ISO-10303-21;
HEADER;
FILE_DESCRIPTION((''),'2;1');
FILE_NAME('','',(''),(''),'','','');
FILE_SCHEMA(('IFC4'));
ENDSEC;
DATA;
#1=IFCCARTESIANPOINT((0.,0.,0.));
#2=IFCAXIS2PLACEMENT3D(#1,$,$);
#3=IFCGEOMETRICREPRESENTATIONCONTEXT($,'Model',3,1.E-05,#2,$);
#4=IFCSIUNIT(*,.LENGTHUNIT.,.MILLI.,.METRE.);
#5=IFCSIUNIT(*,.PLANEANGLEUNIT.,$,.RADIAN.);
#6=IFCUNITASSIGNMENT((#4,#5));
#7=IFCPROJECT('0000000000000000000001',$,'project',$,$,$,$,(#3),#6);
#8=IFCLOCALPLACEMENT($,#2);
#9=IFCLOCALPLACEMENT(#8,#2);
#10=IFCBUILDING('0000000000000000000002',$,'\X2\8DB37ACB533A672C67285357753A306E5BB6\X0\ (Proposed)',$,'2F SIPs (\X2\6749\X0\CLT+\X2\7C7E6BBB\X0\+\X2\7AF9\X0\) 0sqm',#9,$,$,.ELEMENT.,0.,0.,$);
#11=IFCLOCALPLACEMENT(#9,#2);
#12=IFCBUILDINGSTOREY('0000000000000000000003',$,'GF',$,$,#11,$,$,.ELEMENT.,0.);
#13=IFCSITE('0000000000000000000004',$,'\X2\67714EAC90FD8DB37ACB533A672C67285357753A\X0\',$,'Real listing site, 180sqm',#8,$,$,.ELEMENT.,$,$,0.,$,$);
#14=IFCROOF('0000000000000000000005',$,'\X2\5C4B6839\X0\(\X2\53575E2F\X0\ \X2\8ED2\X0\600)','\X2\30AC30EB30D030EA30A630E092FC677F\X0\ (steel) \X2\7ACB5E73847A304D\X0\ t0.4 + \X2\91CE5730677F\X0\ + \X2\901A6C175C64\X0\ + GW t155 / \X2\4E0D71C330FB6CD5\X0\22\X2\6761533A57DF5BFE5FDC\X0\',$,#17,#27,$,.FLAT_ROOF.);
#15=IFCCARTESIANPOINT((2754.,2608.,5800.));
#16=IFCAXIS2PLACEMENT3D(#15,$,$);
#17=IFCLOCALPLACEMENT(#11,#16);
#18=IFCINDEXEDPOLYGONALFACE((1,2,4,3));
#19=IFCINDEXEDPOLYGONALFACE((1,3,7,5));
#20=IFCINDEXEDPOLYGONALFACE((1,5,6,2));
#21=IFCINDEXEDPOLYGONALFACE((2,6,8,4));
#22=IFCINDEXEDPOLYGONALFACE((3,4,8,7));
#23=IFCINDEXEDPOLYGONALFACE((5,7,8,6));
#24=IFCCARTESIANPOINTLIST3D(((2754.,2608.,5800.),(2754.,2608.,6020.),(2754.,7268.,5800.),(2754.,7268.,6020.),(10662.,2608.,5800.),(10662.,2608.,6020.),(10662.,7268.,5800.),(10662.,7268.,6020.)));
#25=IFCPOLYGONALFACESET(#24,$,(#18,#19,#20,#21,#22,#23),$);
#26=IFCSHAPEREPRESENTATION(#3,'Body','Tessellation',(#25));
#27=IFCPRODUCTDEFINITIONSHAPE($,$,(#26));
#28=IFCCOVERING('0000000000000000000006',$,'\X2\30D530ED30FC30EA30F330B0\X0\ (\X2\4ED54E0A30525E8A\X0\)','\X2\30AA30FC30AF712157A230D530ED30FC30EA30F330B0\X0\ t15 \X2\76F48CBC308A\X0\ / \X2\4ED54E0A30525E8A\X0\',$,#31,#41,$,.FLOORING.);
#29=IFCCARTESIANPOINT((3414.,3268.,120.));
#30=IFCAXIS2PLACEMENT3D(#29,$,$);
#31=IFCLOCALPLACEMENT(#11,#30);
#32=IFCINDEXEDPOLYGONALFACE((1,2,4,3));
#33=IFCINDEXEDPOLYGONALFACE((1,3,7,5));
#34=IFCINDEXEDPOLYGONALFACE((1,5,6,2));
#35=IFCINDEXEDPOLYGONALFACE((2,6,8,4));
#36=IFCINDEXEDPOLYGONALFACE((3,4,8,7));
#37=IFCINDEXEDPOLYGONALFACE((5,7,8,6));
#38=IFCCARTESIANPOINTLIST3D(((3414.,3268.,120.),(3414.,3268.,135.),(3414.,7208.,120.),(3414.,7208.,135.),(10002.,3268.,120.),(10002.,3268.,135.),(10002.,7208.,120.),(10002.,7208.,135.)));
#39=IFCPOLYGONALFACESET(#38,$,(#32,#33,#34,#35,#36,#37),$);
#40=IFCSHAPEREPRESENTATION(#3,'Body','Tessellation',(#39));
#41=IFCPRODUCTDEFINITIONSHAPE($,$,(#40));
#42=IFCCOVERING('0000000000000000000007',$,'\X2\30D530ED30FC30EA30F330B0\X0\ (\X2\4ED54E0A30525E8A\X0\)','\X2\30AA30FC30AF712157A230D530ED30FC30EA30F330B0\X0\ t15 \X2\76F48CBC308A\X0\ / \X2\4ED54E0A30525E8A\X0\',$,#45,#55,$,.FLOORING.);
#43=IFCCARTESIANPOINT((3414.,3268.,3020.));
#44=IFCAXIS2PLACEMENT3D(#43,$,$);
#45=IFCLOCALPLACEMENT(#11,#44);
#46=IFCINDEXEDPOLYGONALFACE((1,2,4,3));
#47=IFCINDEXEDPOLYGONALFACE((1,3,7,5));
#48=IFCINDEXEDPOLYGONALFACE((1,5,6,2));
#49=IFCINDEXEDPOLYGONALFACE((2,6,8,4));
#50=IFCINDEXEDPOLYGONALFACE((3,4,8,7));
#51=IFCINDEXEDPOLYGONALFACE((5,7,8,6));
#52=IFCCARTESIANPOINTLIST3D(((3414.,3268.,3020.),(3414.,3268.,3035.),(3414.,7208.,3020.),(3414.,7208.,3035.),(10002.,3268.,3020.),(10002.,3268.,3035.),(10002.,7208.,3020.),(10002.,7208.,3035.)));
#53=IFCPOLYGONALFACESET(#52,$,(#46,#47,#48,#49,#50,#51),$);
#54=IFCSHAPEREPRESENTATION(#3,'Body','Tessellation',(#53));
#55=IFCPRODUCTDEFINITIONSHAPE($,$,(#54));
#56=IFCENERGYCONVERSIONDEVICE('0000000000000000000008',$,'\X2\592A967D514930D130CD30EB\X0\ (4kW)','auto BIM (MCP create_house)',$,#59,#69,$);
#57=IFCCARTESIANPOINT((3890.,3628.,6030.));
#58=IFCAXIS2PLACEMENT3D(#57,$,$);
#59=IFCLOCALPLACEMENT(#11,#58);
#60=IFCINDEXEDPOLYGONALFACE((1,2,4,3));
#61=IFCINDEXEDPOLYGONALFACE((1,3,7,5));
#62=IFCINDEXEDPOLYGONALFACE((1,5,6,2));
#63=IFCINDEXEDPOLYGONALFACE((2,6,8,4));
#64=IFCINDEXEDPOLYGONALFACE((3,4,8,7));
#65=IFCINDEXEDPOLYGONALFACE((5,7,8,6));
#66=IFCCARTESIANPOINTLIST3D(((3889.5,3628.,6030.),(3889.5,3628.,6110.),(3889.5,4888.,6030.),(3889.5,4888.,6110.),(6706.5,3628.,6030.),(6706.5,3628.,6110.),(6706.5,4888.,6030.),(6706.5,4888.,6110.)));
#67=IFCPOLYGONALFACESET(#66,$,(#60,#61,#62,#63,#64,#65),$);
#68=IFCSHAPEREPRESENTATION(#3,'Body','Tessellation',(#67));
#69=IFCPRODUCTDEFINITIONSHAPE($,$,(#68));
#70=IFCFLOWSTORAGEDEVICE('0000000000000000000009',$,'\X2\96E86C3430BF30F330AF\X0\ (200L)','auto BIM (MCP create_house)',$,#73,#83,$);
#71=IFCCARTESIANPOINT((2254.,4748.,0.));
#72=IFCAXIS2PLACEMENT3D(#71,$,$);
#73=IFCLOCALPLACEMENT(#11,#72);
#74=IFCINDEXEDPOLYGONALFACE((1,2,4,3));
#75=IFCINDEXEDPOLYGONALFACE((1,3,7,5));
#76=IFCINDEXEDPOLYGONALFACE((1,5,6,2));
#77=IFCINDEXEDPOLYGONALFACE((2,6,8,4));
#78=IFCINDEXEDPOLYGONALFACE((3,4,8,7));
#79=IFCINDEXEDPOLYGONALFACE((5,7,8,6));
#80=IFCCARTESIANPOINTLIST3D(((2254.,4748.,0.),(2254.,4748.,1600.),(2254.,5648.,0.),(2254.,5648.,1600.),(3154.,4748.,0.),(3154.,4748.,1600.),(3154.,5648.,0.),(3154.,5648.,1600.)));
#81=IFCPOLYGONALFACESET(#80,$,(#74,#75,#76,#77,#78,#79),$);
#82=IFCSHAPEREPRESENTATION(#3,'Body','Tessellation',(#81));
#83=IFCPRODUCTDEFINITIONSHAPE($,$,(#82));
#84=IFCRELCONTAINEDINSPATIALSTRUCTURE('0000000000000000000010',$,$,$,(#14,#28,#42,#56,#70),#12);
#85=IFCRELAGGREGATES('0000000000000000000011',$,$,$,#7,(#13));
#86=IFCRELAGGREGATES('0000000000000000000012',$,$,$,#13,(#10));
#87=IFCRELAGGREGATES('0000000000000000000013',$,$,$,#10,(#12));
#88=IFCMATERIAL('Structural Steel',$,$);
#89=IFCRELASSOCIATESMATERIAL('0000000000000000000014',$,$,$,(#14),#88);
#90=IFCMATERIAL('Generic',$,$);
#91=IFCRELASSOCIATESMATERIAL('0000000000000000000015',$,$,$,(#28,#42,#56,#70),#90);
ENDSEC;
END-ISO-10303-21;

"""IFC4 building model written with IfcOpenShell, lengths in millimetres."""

from ifc_helpers import new_model, si_unit, frame, frame_2d, origin, place, context, project, spatial, rectangle, extrude, material, element, save


model = new_model("IFC4")

# Units and contexts
model_context = context("Model", 3, precision=1e-05, world=origin())
ifc_project = project(units=[si_unit("LENGTHUNIT", "METRE", prefix="MILLI"), si_unit("PLANEANGLEUNIT", "RADIAN")], contexts=[model_context])

# Site, building, storey
site_placement = place(None, origin())
site = spatial("IfcSite", under=ifc_project, at=site_placement, Name="東京都足立区本木南町", ObjectType="Real listing site, 180sqm", CompositionType="ELEMENT", RefElevation=0.0)
building_placement = place(site_placement, origin())
building = spatial("IfcBuilding", under=site, at=building_placement, Name="足立区本木南町の家 (Proposed)", ObjectType="2F SIPs (杉CLT+籾殻+竹) 0sqm", CompositionType="ELEMENT", ElevationOfRefHeight=0.0, ElevationOfTerrain=0.0)
storey_placement = place(building_placement, origin())
storey = spatial("IfcBuildingStorey", under=building, at=storey_placement, Name="GF", CompositionType="ELEMENT", Elevation=0.0)

# Roof
ifc_material_1 = material(Name="Structural Steel")
for number, where, name in (
    (1, (2754.0, 2608.0, 5800.0), "屋根(南帯 軒600)"),
):
    element("IfcRoof", number, at=place(storey_placement, frame(where)), inside=storey, material=ifc_material_1, Name=name, Description="ガルバリウム鋼板 (steel) 立平葺き t0.4 + 野地板 + 通気層 + GW t155 / 不燃・法22条区域対応", PredefinedType="FLAT_ROOF", context=model_context, shape_type="SweptSolid", body=[
        extrude(rectangle(XDim=7908.0, YDim=4660.0, at=frame_2d((3954.0, 2330.0))), frame((2754.0, 2608.0, 5800.0)), (0.0, 0.0, 1.0), 220.0),
    ])

# Coverings
ifc_material_2 = material(Name="Generic")
covering_1_placement = place(storey_placement, frame((3414.0, 3268.0, 120.0)))
element("IfcCovering", 2, at=covering_1_placement, inside=storey, material=ifc_material_2, Name="フローリング (仕上げ床)", Description="オーク無垢フローリング t15 直貼り / 仕上げ床", PredefinedType="FLOORING", context=model_context, shape_type="SweptSolid", body=[
    extrude(rectangle(XDim=6588.0, YDim=3940.0, at=frame_2d((3294.0, 1970.0))), frame((3414.0, 3268.0, 120.0)), (0.0, 0.0, 1.0), 15.0),
])
covering_2_placement = place(storey_placement, frame((3414.0, 3268.0, 3020.0)))
element("IfcCovering", 3, at=covering_2_placement, inside=storey, material=ifc_material_2, Name="フローリング (仕上げ床)", Description="オーク無垢フローリング t15 直貼り / 仕上げ床", PredefinedType="FLOORING", context=model_context, shape_type="SweptSolid", body=[
    extrude(rectangle(XDim=6588.0, YDim=3940.0, at=frame_2d((3294.0, 1970.0))), frame((3414.0, 3268.0, 3020.0)), (0.0, 0.0, 1.0), 15.0),
])

# Energy conversion device
energy_conversion_device_placement = place(storey_placement, frame((3890.0, 3628.0, 6030.0)))
element("IfcEnergyConversionDevice", 4, at=energy_conversion_device_placement, inside=storey, material=ifc_material_2, Name="太陽光パネル (4kW)", Description="auto BIM (MCP create_house)", context=model_context, shape_type="SweptSolid", body=[
    extrude(rectangle(XDim=2817.0, YDim=1260.0, at=frame_2d((1408.0, 630.0))), frame((3890.0, 3628.0, 6030.0)), (0.0, 0.0, 1.0), 80.0),
])

# Flow storage device
flow_storage_device_placement = place(storey_placement, frame((2254.0, 4748.0, 0.0)))
element("IfcFlowStorageDevice", 5, at=flow_storage_device_placement, inside=storey, material=ifc_material_2, Name="雨水タンク (200L)", Description="auto BIM (MCP create_house)", context=model_context, shape_type="SweptSolid", body=[
    extrude(rectangle(XDim=900.0, YDim=900.0, at=frame_2d((450.0, 450.0))), frame((2254.0, 4748.0, 0.0)), (0.0, 0.0, 1.0), 1600.0),
])

save(model, "model.ifc")
